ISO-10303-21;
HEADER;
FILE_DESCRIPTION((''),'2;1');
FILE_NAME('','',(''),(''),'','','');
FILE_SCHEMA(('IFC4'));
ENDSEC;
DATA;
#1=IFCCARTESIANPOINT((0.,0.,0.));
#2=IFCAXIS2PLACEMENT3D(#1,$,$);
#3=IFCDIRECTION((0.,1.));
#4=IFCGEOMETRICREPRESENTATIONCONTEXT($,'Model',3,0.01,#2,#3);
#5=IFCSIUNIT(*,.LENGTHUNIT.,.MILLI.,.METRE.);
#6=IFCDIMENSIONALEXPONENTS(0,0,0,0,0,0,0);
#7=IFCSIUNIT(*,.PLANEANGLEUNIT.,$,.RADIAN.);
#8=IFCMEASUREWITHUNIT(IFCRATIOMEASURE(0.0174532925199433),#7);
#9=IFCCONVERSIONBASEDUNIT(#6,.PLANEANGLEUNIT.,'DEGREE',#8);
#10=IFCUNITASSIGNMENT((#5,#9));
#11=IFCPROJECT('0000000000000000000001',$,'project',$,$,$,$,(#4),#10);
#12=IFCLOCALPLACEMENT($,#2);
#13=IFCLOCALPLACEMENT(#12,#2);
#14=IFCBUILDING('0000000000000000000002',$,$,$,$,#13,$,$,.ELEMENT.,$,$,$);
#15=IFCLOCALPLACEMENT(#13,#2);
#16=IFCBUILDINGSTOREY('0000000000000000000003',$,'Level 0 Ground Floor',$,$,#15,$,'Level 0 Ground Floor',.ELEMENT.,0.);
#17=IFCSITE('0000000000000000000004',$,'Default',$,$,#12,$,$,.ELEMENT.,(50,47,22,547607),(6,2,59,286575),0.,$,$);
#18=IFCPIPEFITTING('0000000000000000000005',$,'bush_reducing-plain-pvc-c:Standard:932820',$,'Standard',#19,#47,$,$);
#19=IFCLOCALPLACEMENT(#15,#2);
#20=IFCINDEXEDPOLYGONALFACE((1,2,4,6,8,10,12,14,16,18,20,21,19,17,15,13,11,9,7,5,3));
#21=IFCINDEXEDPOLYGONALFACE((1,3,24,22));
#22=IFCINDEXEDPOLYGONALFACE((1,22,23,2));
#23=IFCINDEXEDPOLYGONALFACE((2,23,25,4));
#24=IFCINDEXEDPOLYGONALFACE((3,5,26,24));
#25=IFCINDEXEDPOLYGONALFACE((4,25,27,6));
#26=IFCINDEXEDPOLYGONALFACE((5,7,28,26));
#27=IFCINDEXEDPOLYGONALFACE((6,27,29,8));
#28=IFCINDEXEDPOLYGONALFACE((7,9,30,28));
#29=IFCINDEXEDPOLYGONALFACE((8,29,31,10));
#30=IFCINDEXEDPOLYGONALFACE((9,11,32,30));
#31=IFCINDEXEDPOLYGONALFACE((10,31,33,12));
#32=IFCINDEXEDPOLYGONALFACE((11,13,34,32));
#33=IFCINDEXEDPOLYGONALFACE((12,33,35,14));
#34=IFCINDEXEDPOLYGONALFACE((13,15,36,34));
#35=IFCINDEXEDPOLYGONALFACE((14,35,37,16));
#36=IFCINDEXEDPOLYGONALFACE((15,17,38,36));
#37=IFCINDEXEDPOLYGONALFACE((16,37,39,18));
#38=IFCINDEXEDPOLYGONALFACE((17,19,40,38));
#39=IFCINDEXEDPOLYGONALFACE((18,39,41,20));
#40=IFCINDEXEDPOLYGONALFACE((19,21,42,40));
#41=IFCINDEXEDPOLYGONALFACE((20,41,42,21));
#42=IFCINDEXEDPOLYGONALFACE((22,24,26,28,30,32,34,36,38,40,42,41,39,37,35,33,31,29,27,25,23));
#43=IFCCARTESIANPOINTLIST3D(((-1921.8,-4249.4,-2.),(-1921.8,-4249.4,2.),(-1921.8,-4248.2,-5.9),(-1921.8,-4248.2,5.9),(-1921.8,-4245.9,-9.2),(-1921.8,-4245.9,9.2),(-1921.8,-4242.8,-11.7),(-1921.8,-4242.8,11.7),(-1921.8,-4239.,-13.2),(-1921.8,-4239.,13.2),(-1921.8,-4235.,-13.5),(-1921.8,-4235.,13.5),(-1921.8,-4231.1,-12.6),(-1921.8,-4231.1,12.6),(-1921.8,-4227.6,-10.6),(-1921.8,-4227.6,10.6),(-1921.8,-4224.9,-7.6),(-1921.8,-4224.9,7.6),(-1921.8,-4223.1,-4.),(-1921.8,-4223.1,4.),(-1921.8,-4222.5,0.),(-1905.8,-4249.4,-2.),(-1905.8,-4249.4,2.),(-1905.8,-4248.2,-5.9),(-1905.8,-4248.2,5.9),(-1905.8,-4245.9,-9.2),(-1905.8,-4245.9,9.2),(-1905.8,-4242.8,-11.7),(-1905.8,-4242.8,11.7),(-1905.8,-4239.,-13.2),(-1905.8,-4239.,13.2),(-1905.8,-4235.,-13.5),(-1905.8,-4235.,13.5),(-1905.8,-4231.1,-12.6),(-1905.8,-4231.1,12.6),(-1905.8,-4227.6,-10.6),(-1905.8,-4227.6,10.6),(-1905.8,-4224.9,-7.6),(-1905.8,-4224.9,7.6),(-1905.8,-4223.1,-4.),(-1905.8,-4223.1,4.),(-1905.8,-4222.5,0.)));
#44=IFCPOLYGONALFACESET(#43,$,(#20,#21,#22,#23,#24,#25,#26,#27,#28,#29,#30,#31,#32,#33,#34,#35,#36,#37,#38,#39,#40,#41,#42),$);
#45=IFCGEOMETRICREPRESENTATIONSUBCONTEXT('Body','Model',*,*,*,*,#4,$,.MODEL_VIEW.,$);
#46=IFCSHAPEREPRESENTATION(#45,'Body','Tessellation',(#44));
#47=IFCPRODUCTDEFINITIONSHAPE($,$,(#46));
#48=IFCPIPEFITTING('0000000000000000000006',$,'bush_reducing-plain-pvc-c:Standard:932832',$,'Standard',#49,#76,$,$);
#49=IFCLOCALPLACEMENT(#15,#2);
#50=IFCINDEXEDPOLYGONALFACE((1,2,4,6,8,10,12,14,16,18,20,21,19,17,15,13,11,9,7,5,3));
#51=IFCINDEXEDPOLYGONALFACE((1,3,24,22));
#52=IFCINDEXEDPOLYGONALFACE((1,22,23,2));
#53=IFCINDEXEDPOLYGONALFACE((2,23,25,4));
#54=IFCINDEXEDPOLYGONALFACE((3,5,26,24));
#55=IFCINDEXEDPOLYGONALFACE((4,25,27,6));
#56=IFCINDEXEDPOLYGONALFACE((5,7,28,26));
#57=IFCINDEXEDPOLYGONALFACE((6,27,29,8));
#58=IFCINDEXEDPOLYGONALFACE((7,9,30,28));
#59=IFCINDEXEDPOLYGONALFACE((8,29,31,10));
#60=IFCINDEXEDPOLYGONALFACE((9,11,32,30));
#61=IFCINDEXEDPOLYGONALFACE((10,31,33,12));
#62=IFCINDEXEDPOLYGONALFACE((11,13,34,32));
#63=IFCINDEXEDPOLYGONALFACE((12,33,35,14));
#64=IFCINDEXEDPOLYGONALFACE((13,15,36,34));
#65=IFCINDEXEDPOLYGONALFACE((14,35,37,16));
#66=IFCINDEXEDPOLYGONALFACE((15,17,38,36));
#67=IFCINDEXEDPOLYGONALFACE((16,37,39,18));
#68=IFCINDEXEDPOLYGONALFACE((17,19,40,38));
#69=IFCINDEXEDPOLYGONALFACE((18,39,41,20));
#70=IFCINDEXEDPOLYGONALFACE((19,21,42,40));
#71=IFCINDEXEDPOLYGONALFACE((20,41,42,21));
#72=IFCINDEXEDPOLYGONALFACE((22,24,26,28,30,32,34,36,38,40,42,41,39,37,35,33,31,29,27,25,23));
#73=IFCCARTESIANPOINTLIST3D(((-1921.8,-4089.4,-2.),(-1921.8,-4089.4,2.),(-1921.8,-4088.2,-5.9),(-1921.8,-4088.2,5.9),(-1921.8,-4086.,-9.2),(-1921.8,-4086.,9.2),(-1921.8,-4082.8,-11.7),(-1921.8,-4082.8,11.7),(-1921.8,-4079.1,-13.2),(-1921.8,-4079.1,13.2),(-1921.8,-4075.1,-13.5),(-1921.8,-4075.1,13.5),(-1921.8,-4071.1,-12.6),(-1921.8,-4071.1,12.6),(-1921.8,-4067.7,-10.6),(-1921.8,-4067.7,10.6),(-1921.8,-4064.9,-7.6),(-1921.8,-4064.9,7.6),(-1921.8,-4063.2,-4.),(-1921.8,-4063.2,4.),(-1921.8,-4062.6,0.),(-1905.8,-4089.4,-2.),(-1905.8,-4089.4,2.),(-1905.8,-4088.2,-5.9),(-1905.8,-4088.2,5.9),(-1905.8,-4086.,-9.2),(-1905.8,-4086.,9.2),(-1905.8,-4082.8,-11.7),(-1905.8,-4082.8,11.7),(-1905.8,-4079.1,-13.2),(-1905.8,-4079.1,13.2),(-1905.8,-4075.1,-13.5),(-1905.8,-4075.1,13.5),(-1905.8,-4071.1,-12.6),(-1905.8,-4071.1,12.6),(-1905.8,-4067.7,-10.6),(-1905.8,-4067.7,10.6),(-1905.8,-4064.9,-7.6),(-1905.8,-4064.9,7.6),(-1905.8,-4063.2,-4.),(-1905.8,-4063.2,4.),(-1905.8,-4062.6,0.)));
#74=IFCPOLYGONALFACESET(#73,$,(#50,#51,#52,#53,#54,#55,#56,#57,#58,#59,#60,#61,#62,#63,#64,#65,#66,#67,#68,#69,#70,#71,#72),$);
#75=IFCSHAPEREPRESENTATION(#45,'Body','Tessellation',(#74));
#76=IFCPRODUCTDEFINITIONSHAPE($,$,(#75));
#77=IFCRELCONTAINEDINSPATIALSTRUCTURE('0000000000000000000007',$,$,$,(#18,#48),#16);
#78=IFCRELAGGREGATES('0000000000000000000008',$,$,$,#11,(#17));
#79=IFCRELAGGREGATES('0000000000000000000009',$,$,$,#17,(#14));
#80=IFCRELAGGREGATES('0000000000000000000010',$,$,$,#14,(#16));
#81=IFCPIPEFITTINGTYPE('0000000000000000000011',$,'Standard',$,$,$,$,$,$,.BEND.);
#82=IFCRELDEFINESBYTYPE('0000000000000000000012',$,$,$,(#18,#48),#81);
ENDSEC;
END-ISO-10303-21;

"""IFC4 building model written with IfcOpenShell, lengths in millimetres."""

from ifc_helpers import new_model, entity, si_unit, converted_unit, direction, frame, frame_2d, origin, place, context, subcontext, project, spatial, circle, extrude, source, transform, mapped, type_object, type_shapes, element, save


model = new_model("IFC4")

# Units and contexts
model_context = context("Model", 3, precision=0.01, world=origin(), true_north=direction((0.0, 1.0)))
body_context = subcontext(model_context, "Body", "Model", "MODEL_VIEW")
ifc_project = project(units=[si_unit("LENGTHUNIT", "METRE", prefix="MILLI"), converted_unit("PLANEANGLEUNIT", "DEGREE", entity("IfcRatioMeasure", 0.0174532925199433), si_unit("PLANEANGLEUNIT", "RADIAN"), dimensions=[0, 0, 0, 0, 0, 0, 0])], contexts=[model_context])

# Site, building, storey
site_placement = place(None, origin())
site = spatial("IfcSite", under=ifc_project, at=site_placement, Name="Default", CompositionType="ELEMENT", RefLatitude=(50, 47, 22, 547607), RefLongitude=(6, 2, 59, 286575), RefElevation=0.0)
building_placement = place(site_placement, origin())
building = spatial("IfcBuilding", under=site, at=building_placement, CompositionType="ELEMENT")
storey_placement = place(building_placement, origin())
storey = spatial("IfcBuildingStorey", under=building, at=storey_placement, Name="Level 0 Ground Floor", LongName="Level 0 Ground Floor", CompositionType="ELEMENT", Elevation=0.0)

# Pipe fittings
pipe_fitting_type = type_object("IfcPipeFittingType", Name="Standard", PredefinedType="BEND")
shared_shape_1 = source(origin(), body_context, "Body", "SweptSolid", [
    extrude(circle(Radius=13.5, at=frame_2d((0.0, 0.0), x_axis=(1.0, 0.0))), frame((0.0, 0.0, 0.0), z_axis=(1.0, 0.0, 0.0), x_axis=(0.0, 1.0, 0.0)), (0.0, 0.0, 1.0), 16.0),
])
type_shapes(pipe_fitting_type, [shared_shape_1])
for number, where, name in (
    (1, (-1921.8, -4236.0, 0.0), "bush_reducing-plain-pvc-c:Standard:932820"),
    (2, (-1921.8, -4076.1, 0.0), "bush_reducing-plain-pvc-c:Standard:932832"),
):
    element("IfcPipeFitting", number, at=place(storey_placement, frame(where)), inside=storey, type_object=pipe_fitting_type, Name=name, ObjectType="Standard", context=body_context, shape_type="MappedRepresentation", body=[
        mapped(shared_shape_1, transform((0.0, 0.0, 0.0), scale=1.0)),
    ])

save(model, "model.ifc")
